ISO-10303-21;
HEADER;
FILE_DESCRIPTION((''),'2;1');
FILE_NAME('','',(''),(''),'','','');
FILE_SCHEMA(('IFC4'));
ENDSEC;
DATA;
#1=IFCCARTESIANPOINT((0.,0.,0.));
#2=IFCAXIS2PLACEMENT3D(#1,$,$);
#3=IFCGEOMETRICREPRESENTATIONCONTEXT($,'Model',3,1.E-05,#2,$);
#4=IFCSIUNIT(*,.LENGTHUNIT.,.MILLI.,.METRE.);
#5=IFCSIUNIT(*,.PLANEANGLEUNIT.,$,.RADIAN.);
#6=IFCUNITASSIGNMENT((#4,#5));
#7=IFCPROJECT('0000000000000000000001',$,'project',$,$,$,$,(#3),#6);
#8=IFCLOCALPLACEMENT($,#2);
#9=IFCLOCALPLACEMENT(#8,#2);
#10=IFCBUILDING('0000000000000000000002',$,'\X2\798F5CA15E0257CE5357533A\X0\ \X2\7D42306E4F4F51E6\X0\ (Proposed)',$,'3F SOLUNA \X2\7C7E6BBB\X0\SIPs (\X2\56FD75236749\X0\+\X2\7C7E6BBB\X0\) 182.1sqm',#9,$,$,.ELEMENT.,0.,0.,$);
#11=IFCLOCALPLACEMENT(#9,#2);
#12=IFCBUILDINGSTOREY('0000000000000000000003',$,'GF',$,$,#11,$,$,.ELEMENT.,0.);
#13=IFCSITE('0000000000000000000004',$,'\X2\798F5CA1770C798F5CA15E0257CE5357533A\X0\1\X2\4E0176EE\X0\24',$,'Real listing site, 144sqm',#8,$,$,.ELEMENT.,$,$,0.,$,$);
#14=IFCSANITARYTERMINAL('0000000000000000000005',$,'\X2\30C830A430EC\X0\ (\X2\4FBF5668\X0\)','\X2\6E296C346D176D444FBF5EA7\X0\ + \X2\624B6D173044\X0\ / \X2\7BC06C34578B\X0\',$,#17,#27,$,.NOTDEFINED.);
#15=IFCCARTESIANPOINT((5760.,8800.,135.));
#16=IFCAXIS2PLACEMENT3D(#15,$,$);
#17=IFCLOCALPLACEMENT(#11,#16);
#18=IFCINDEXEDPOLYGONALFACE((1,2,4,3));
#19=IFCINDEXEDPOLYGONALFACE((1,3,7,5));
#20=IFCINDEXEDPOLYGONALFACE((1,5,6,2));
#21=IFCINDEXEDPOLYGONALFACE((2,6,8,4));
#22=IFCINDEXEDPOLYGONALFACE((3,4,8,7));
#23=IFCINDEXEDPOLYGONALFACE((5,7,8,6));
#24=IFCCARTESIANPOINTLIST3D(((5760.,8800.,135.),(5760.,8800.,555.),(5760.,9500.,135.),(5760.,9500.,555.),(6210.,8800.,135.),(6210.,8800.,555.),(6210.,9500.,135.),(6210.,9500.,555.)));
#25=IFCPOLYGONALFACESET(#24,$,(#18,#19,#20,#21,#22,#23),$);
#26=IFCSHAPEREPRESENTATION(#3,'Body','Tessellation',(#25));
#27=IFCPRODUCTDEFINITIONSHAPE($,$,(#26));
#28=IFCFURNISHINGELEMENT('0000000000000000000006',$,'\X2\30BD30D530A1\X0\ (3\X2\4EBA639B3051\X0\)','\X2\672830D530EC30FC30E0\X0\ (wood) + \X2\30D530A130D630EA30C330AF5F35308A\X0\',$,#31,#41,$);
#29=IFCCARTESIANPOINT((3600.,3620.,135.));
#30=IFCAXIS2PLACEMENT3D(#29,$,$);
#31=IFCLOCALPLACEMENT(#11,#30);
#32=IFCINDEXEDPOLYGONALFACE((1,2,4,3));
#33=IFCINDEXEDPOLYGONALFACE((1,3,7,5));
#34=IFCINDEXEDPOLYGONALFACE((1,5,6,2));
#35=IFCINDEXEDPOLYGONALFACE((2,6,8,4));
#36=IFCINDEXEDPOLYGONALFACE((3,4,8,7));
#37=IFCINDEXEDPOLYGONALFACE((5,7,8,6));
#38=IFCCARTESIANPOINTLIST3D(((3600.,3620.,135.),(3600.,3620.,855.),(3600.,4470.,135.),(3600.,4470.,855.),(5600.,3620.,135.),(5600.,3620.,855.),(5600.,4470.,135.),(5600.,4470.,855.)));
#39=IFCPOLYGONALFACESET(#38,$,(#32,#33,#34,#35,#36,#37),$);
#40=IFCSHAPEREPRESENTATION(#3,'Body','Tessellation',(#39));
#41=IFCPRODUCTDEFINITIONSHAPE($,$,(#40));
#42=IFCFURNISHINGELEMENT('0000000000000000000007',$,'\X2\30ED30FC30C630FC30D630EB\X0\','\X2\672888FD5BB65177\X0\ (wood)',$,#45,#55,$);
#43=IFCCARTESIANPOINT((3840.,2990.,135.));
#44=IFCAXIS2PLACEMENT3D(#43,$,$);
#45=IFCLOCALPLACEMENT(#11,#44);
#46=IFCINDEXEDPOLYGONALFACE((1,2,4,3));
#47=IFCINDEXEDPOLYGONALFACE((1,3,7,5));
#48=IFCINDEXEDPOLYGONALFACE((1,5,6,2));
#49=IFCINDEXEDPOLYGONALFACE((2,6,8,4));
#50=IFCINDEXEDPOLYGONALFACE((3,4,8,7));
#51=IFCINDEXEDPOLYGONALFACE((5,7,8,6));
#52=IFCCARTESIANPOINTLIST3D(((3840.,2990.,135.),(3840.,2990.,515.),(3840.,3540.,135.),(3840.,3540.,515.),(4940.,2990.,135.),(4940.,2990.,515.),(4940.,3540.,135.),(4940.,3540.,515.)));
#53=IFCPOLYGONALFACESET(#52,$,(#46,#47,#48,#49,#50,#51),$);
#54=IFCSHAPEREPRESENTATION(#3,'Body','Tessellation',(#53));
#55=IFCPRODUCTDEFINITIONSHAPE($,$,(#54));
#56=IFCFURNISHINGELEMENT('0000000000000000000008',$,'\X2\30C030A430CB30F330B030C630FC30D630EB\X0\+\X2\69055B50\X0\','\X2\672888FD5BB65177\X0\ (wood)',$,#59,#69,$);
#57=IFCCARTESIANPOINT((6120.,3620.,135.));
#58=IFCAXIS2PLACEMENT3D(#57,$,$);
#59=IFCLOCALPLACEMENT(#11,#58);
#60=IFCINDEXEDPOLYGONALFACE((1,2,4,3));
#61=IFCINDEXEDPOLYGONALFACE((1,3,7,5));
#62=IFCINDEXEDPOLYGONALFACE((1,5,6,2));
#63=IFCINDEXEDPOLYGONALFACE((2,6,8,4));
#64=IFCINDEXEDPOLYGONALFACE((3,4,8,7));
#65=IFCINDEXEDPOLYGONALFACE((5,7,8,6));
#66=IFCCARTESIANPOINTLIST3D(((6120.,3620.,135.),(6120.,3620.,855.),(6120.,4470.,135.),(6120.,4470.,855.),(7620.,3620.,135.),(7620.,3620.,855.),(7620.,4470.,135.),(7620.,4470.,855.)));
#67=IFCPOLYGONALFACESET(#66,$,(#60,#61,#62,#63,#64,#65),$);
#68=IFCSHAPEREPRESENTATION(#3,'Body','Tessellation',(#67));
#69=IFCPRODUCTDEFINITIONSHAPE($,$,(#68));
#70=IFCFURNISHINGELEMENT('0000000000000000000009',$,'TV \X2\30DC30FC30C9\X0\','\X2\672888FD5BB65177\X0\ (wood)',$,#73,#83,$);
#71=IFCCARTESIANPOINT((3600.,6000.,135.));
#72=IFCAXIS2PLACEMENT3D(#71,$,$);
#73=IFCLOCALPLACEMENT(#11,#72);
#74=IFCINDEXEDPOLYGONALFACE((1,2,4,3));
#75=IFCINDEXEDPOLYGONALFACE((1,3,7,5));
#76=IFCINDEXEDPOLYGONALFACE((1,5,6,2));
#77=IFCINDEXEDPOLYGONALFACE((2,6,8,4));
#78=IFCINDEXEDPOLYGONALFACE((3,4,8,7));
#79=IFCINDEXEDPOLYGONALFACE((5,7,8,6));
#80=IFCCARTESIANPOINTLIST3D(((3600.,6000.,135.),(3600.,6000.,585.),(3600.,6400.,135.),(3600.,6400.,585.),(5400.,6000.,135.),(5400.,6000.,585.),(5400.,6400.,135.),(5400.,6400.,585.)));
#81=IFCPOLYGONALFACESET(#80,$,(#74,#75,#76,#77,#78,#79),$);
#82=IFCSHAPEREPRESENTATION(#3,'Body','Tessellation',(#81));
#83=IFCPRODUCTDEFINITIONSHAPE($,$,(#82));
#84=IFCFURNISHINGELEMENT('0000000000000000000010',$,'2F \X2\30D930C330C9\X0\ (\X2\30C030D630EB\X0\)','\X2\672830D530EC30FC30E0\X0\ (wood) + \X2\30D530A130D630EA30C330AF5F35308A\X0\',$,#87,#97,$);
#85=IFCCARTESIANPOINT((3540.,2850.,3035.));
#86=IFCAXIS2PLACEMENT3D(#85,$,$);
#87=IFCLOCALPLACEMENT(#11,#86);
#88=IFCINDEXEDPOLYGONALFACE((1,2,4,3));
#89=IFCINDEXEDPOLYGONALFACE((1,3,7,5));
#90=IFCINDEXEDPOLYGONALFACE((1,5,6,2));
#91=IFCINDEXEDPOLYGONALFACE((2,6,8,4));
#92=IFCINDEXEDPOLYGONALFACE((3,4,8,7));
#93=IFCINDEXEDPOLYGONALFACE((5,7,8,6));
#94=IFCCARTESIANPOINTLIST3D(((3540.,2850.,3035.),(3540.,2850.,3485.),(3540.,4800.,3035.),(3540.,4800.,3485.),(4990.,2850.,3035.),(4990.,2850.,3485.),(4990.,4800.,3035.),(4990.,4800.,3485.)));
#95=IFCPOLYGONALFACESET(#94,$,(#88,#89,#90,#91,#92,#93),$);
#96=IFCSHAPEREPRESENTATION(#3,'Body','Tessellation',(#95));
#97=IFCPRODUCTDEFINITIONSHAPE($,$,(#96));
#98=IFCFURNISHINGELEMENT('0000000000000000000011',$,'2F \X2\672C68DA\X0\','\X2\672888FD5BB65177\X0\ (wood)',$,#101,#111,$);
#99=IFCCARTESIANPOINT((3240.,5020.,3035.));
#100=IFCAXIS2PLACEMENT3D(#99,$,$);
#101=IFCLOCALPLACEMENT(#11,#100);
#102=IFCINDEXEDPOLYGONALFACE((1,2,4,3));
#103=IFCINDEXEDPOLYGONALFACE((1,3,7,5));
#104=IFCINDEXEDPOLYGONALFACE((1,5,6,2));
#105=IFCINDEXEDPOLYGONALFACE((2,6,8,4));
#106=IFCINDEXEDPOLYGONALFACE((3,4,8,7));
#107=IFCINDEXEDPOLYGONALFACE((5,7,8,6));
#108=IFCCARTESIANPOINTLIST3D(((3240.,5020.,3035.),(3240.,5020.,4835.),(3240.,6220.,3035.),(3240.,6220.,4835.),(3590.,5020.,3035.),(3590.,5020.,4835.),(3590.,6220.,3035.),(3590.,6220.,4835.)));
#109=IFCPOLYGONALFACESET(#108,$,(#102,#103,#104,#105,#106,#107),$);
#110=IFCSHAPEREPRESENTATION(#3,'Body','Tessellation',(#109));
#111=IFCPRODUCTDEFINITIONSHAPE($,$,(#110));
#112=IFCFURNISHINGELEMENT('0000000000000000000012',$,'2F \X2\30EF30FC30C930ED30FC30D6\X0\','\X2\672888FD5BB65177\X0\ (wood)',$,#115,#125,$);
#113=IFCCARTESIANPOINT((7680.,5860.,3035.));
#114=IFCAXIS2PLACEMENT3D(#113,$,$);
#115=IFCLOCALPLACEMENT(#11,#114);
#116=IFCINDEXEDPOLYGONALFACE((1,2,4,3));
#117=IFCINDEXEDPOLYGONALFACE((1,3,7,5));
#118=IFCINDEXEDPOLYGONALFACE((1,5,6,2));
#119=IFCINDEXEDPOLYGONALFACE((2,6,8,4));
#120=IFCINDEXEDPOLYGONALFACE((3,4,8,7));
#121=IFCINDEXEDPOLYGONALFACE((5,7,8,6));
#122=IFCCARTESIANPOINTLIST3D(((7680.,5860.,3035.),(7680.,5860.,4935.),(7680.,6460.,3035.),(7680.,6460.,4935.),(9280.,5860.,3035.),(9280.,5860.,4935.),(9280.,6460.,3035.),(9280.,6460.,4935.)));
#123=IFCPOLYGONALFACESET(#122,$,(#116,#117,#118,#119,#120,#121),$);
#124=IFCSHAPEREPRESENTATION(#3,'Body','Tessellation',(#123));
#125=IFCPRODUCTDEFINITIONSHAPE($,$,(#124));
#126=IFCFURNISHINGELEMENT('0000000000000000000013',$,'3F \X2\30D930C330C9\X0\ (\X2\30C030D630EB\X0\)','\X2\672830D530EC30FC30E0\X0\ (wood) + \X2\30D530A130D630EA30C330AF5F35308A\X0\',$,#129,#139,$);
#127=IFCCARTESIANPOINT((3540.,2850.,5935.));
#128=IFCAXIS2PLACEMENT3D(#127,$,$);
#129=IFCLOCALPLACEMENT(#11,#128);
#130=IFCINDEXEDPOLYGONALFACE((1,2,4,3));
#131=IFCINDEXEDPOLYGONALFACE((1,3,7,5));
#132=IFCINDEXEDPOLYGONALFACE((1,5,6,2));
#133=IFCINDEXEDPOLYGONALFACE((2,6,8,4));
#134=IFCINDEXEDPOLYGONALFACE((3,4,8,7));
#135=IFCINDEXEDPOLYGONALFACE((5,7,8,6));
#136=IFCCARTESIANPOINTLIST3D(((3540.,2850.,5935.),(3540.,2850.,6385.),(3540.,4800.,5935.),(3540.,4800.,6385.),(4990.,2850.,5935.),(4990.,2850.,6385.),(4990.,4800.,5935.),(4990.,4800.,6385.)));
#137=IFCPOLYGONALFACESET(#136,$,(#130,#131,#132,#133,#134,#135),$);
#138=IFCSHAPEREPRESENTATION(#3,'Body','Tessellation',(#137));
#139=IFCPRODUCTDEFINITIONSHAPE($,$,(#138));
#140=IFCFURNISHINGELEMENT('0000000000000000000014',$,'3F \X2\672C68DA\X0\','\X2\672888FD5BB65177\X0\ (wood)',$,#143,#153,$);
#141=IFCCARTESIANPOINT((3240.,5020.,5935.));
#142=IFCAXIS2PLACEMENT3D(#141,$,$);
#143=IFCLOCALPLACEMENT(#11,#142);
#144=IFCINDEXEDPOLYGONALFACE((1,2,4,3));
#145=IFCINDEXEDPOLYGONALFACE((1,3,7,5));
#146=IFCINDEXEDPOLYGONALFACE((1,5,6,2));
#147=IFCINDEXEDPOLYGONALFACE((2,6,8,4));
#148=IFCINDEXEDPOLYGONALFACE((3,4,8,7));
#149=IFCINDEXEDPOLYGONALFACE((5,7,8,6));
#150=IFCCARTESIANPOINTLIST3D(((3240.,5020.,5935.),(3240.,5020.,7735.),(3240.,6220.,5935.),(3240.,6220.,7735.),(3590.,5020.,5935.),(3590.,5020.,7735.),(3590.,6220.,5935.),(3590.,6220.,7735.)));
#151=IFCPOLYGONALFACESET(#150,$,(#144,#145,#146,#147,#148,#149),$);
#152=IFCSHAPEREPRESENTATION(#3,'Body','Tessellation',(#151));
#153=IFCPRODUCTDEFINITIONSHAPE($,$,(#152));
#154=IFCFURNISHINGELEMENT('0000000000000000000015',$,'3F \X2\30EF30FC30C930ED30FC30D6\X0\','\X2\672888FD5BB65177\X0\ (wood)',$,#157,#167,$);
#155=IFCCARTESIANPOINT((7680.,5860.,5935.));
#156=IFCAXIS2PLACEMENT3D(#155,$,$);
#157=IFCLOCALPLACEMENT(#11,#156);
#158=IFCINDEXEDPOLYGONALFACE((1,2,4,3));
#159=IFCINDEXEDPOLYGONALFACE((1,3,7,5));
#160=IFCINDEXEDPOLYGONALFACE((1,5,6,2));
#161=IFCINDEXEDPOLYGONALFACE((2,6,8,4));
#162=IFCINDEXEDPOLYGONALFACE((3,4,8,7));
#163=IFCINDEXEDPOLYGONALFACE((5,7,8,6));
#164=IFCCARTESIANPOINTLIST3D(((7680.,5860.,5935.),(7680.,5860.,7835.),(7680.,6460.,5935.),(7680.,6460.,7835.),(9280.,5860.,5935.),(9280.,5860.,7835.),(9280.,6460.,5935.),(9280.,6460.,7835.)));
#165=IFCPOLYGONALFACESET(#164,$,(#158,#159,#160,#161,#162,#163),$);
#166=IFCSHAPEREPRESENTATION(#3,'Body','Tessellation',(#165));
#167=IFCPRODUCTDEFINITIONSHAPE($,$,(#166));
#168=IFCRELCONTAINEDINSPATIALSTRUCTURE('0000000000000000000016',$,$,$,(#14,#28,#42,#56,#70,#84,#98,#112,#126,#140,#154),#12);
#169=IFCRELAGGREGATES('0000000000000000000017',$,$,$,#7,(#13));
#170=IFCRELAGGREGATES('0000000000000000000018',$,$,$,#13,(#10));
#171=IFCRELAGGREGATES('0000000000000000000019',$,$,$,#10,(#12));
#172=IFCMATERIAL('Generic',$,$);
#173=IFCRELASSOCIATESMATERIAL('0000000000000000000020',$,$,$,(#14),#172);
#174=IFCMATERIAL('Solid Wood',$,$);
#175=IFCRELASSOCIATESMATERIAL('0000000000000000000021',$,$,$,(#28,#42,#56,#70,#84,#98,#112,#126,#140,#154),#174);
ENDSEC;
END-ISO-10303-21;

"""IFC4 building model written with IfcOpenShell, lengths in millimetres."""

from ifc_helpers import new_model, si_unit, frame, frame_2d, origin, place, context, project, spatial, rectangle, extrude, material, element, save


model = new_model("IFC4")

# Units and contexts
model_context = context("Model", 3, precision=1e-05, world=origin())
ifc_project = project(units=[si_unit("LENGTHUNIT", "METRE", prefix="MILLI"), si_unit("PLANEANGLEUNIT", "RADIAN")], contexts=[model_context])

# Site, building, storey
site_placement = place(None, origin())
site = spatial("IfcSite", under=ifc_project, at=site_placement, Name="福岡県福岡市城南区1丁目24", ObjectType="Real listing site, 144sqm", CompositionType="ELEMENT", RefElevation=0.0)
building_placement = place(site_placement, origin())
building = spatial("IfcBuilding", under=site, at=building_placement, Name="福岡市城南区 終の住処 (Proposed)", ObjectType="3F SOLUNA 籾殻SIPs (国産杉+籾殻) 182.1sqm", CompositionType="ELEMENT", ElevationOfRefHeight=0.0, ElevationOfTerrain=0.0)
storey_placement = place(building_placement, origin())
storey = spatial("IfcBuildingStorey", under=building, at=storey_placement, Name="GF", CompositionType="ELEMENT", Elevation=0.0)

# Shared definitions
ifc_material_1 = material(Name="Generic")

# Shared definitions
ifc_material_2 = material(Name="Solid Wood")

# Sanitary terminal
sanitary_terminal_1_placement = place(storey_placement, frame((5760.0, 8800.0, 135.0)))
element("IfcSanitaryTerminal", 1, at=sanitary_terminal_1_placement, inside=storey, material=ifc_material_1, Name="トイレ (便器)", Description="温水洗浄便座 + 手洗い / 節水型", PredefinedType="NOTDEFINED", context=model_context, shape_type="SweptSolid", body=[
    extrude(rectangle(XDim=450.0, YDim=700.0, at=frame_2d((225.0, 350.0))), frame((5760.0, 8800.0, 135.0)), (0.0, 0.0, 1.0), 420.0),
])

# Furnishing elements
furnishing_1_placement = place(storey_placement, frame((3600.0, 3620.0, 135.0)))
element("IfcFurnishingElement", 2, at=furnishing_1_placement, inside=storey, material=ifc_material_2, Name="ソファ (3人掛け)", Description="木フレーム (wood) + ファブリック張り", context=model_context, shape_type="SweptSolid", body=[
    extrude(rectangle(XDim=2000.0, YDim=850.0, at=frame_2d((1000.0, 425.0))), frame((3600.0, 3620.0, 135.0)), (0.0, 0.0, 1.0), 720.0),
])
furnishing_2_placement = place(storey_placement, frame((3840.0, 2990.0, 135.0)))
element("IfcFurnishingElement", 3, at=furnishing_2_placement, inside=storey, material=ifc_material_2, Name="ローテーブル", Description="木製家具 (wood)", context=model_context, shape_type="SweptSolid", body=[
    extrude(rectangle(XDim=1100.0, YDim=550.0, at=frame_2d((550.0, 275.0))), frame((3840.0, 2990.0, 135.0)), (0.0, 0.0, 1.0), 380.0),
])
furnishing_3_placement = place(storey_placement, frame((6120.0, 3620.0, 135.0)))
element("IfcFurnishingElement", 4, at=furnishing_3_placement, inside=storey, material=ifc_material_2, Name="ダイニングテーブル+椅子", Description="木製家具 (wood)", context=model_context, shape_type="SweptSolid", body=[
    extrude(rectangle(XDim=1500.0, YDim=850.0, at=frame_2d((750.0, 425.0))), frame((6120.0, 3620.0, 135.0)), (0.0, 0.0, 1.0), 720.0),
])
furnishing_4_placement = place(storey_placement, frame((3600.0, 6000.0, 135.0)))
element("IfcFurnishingElement", 5, at=furnishing_4_placement, inside=storey, material=ifc_material_2, Name="TV ボード", Description="木製家具 (wood)", context=model_context, shape_type="SweptSolid", body=[
    extrude(rectangle(XDim=1800.0, YDim=400.0, at=frame_2d((900.0, 200.0))), frame((3600.0, 6000.0, 135.0)), (0.0, 0.0, 1.0), 450.0),
])
furnishing_5_placement = place(storey_placement, frame((3540.0, 2850.0, 3035.0)))
element("IfcFurnishingElement", 6, at=furnishing_5_placement, inside=storey, material=ifc_material_2, Name="2F ベッド (ダブル)", Description="木フレーム (wood) + ファブリック張り", context=model_context, shape_type="SweptSolid", body=[
    extrude(rectangle(XDim=1450.0, YDim=1950.0, at=frame_2d((725.0, 975.0))), frame((3540.0, 2850.0, 3035.0)), (0.0, 0.0, 1.0), 450.0),
])
furnishing_6_placement = place(storey_placement, frame((3240.0, 5020.0, 3035.0)))
element("IfcFurnishingElement", 7, at=furnishing_6_placement, inside=storey, material=ifc_material_2, Name="2F 本棚", Description="木製家具 (wood)", context=model_context, shape_type="SweptSolid", body=[
    extrude(rectangle(XDim=350.0, YDim=1200.0, at=frame_2d((175.0, 600.0))), frame((3240.0, 5020.0, 3035.0)), (0.0, 0.0, 1.0), 1800.0),
])
furnishing_7_placement = place(storey_placement, frame((7680.0, 5860.0, 3035.0)))
element("IfcFurnishingElement", 8, at=furnishing_7_placement, inside=storey, material=ifc_material_2, Name="2F ワードローブ", Description="木製家具 (wood)", context=model_context, shape_type="SweptSolid", body=[
    extrude(rectangle(XDim=1600.0, YDim=600.0, at=frame_2d((800.0, 300.0))), frame((7680.0, 5860.0, 3035.0)), (0.0, 0.0, 1.0), 1900.0),
])
furnishing_8_placement = place(storey_placement, frame((3540.0, 2850.0, 5935.0)))
element("IfcFurnishingElement", 9, at=furnishing_8_placement, inside=storey, material=ifc_material_2, Name="3F ベッド (ダブル)", Description="木フレーム (wood) + ファブリック張り", context=model_context, shape_type="SweptSolid", body=[
    extrude(rectangle(XDim=1450.0, YDim=1950.0, at=frame_2d((725.0, 975.0))), frame((3540.0, 2850.0, 5935.0)), (0.0, 0.0, 1.0), 450.0),
])
furnishing_9_placement = place(storey_placement, frame((3240.0, 5020.0, 5935.0)))
element("IfcFurnishingElement", 10, at=furnishing_9_placement, inside=storey, material=ifc_material_2, Name="3F 本棚", Description="木製家具 (wood)", context=model_context, shape_type="SweptSolid", body=[
    extrude(rectangle(XDim=350.0, YDim=1200.0, at=frame_2d((175.0, 600.0))), frame((3240.0, 5020.0, 5935.0)), (0.0, 0.0, 1.0), 1800.0),
])
furnishing_10_placement = place(storey_placement, frame((7680.0, 5860.0, 5935.0)))
element("IfcFurnishingElement", 11, at=furnishing_10_placement, inside=storey, material=ifc_material_2, Name="3F ワードローブ", Description="木製家具 (wood)", context=model_context, shape_type="SweptSolid", body=[
    extrude(rectangle(XDim=1600.0, YDim=600.0, at=frame_2d((800.0, 300.0))), frame((7680.0, 5860.0, 5935.0)), (0.0, 0.0, 1.0), 1900.0),
])

save(model, "model.ifc")
